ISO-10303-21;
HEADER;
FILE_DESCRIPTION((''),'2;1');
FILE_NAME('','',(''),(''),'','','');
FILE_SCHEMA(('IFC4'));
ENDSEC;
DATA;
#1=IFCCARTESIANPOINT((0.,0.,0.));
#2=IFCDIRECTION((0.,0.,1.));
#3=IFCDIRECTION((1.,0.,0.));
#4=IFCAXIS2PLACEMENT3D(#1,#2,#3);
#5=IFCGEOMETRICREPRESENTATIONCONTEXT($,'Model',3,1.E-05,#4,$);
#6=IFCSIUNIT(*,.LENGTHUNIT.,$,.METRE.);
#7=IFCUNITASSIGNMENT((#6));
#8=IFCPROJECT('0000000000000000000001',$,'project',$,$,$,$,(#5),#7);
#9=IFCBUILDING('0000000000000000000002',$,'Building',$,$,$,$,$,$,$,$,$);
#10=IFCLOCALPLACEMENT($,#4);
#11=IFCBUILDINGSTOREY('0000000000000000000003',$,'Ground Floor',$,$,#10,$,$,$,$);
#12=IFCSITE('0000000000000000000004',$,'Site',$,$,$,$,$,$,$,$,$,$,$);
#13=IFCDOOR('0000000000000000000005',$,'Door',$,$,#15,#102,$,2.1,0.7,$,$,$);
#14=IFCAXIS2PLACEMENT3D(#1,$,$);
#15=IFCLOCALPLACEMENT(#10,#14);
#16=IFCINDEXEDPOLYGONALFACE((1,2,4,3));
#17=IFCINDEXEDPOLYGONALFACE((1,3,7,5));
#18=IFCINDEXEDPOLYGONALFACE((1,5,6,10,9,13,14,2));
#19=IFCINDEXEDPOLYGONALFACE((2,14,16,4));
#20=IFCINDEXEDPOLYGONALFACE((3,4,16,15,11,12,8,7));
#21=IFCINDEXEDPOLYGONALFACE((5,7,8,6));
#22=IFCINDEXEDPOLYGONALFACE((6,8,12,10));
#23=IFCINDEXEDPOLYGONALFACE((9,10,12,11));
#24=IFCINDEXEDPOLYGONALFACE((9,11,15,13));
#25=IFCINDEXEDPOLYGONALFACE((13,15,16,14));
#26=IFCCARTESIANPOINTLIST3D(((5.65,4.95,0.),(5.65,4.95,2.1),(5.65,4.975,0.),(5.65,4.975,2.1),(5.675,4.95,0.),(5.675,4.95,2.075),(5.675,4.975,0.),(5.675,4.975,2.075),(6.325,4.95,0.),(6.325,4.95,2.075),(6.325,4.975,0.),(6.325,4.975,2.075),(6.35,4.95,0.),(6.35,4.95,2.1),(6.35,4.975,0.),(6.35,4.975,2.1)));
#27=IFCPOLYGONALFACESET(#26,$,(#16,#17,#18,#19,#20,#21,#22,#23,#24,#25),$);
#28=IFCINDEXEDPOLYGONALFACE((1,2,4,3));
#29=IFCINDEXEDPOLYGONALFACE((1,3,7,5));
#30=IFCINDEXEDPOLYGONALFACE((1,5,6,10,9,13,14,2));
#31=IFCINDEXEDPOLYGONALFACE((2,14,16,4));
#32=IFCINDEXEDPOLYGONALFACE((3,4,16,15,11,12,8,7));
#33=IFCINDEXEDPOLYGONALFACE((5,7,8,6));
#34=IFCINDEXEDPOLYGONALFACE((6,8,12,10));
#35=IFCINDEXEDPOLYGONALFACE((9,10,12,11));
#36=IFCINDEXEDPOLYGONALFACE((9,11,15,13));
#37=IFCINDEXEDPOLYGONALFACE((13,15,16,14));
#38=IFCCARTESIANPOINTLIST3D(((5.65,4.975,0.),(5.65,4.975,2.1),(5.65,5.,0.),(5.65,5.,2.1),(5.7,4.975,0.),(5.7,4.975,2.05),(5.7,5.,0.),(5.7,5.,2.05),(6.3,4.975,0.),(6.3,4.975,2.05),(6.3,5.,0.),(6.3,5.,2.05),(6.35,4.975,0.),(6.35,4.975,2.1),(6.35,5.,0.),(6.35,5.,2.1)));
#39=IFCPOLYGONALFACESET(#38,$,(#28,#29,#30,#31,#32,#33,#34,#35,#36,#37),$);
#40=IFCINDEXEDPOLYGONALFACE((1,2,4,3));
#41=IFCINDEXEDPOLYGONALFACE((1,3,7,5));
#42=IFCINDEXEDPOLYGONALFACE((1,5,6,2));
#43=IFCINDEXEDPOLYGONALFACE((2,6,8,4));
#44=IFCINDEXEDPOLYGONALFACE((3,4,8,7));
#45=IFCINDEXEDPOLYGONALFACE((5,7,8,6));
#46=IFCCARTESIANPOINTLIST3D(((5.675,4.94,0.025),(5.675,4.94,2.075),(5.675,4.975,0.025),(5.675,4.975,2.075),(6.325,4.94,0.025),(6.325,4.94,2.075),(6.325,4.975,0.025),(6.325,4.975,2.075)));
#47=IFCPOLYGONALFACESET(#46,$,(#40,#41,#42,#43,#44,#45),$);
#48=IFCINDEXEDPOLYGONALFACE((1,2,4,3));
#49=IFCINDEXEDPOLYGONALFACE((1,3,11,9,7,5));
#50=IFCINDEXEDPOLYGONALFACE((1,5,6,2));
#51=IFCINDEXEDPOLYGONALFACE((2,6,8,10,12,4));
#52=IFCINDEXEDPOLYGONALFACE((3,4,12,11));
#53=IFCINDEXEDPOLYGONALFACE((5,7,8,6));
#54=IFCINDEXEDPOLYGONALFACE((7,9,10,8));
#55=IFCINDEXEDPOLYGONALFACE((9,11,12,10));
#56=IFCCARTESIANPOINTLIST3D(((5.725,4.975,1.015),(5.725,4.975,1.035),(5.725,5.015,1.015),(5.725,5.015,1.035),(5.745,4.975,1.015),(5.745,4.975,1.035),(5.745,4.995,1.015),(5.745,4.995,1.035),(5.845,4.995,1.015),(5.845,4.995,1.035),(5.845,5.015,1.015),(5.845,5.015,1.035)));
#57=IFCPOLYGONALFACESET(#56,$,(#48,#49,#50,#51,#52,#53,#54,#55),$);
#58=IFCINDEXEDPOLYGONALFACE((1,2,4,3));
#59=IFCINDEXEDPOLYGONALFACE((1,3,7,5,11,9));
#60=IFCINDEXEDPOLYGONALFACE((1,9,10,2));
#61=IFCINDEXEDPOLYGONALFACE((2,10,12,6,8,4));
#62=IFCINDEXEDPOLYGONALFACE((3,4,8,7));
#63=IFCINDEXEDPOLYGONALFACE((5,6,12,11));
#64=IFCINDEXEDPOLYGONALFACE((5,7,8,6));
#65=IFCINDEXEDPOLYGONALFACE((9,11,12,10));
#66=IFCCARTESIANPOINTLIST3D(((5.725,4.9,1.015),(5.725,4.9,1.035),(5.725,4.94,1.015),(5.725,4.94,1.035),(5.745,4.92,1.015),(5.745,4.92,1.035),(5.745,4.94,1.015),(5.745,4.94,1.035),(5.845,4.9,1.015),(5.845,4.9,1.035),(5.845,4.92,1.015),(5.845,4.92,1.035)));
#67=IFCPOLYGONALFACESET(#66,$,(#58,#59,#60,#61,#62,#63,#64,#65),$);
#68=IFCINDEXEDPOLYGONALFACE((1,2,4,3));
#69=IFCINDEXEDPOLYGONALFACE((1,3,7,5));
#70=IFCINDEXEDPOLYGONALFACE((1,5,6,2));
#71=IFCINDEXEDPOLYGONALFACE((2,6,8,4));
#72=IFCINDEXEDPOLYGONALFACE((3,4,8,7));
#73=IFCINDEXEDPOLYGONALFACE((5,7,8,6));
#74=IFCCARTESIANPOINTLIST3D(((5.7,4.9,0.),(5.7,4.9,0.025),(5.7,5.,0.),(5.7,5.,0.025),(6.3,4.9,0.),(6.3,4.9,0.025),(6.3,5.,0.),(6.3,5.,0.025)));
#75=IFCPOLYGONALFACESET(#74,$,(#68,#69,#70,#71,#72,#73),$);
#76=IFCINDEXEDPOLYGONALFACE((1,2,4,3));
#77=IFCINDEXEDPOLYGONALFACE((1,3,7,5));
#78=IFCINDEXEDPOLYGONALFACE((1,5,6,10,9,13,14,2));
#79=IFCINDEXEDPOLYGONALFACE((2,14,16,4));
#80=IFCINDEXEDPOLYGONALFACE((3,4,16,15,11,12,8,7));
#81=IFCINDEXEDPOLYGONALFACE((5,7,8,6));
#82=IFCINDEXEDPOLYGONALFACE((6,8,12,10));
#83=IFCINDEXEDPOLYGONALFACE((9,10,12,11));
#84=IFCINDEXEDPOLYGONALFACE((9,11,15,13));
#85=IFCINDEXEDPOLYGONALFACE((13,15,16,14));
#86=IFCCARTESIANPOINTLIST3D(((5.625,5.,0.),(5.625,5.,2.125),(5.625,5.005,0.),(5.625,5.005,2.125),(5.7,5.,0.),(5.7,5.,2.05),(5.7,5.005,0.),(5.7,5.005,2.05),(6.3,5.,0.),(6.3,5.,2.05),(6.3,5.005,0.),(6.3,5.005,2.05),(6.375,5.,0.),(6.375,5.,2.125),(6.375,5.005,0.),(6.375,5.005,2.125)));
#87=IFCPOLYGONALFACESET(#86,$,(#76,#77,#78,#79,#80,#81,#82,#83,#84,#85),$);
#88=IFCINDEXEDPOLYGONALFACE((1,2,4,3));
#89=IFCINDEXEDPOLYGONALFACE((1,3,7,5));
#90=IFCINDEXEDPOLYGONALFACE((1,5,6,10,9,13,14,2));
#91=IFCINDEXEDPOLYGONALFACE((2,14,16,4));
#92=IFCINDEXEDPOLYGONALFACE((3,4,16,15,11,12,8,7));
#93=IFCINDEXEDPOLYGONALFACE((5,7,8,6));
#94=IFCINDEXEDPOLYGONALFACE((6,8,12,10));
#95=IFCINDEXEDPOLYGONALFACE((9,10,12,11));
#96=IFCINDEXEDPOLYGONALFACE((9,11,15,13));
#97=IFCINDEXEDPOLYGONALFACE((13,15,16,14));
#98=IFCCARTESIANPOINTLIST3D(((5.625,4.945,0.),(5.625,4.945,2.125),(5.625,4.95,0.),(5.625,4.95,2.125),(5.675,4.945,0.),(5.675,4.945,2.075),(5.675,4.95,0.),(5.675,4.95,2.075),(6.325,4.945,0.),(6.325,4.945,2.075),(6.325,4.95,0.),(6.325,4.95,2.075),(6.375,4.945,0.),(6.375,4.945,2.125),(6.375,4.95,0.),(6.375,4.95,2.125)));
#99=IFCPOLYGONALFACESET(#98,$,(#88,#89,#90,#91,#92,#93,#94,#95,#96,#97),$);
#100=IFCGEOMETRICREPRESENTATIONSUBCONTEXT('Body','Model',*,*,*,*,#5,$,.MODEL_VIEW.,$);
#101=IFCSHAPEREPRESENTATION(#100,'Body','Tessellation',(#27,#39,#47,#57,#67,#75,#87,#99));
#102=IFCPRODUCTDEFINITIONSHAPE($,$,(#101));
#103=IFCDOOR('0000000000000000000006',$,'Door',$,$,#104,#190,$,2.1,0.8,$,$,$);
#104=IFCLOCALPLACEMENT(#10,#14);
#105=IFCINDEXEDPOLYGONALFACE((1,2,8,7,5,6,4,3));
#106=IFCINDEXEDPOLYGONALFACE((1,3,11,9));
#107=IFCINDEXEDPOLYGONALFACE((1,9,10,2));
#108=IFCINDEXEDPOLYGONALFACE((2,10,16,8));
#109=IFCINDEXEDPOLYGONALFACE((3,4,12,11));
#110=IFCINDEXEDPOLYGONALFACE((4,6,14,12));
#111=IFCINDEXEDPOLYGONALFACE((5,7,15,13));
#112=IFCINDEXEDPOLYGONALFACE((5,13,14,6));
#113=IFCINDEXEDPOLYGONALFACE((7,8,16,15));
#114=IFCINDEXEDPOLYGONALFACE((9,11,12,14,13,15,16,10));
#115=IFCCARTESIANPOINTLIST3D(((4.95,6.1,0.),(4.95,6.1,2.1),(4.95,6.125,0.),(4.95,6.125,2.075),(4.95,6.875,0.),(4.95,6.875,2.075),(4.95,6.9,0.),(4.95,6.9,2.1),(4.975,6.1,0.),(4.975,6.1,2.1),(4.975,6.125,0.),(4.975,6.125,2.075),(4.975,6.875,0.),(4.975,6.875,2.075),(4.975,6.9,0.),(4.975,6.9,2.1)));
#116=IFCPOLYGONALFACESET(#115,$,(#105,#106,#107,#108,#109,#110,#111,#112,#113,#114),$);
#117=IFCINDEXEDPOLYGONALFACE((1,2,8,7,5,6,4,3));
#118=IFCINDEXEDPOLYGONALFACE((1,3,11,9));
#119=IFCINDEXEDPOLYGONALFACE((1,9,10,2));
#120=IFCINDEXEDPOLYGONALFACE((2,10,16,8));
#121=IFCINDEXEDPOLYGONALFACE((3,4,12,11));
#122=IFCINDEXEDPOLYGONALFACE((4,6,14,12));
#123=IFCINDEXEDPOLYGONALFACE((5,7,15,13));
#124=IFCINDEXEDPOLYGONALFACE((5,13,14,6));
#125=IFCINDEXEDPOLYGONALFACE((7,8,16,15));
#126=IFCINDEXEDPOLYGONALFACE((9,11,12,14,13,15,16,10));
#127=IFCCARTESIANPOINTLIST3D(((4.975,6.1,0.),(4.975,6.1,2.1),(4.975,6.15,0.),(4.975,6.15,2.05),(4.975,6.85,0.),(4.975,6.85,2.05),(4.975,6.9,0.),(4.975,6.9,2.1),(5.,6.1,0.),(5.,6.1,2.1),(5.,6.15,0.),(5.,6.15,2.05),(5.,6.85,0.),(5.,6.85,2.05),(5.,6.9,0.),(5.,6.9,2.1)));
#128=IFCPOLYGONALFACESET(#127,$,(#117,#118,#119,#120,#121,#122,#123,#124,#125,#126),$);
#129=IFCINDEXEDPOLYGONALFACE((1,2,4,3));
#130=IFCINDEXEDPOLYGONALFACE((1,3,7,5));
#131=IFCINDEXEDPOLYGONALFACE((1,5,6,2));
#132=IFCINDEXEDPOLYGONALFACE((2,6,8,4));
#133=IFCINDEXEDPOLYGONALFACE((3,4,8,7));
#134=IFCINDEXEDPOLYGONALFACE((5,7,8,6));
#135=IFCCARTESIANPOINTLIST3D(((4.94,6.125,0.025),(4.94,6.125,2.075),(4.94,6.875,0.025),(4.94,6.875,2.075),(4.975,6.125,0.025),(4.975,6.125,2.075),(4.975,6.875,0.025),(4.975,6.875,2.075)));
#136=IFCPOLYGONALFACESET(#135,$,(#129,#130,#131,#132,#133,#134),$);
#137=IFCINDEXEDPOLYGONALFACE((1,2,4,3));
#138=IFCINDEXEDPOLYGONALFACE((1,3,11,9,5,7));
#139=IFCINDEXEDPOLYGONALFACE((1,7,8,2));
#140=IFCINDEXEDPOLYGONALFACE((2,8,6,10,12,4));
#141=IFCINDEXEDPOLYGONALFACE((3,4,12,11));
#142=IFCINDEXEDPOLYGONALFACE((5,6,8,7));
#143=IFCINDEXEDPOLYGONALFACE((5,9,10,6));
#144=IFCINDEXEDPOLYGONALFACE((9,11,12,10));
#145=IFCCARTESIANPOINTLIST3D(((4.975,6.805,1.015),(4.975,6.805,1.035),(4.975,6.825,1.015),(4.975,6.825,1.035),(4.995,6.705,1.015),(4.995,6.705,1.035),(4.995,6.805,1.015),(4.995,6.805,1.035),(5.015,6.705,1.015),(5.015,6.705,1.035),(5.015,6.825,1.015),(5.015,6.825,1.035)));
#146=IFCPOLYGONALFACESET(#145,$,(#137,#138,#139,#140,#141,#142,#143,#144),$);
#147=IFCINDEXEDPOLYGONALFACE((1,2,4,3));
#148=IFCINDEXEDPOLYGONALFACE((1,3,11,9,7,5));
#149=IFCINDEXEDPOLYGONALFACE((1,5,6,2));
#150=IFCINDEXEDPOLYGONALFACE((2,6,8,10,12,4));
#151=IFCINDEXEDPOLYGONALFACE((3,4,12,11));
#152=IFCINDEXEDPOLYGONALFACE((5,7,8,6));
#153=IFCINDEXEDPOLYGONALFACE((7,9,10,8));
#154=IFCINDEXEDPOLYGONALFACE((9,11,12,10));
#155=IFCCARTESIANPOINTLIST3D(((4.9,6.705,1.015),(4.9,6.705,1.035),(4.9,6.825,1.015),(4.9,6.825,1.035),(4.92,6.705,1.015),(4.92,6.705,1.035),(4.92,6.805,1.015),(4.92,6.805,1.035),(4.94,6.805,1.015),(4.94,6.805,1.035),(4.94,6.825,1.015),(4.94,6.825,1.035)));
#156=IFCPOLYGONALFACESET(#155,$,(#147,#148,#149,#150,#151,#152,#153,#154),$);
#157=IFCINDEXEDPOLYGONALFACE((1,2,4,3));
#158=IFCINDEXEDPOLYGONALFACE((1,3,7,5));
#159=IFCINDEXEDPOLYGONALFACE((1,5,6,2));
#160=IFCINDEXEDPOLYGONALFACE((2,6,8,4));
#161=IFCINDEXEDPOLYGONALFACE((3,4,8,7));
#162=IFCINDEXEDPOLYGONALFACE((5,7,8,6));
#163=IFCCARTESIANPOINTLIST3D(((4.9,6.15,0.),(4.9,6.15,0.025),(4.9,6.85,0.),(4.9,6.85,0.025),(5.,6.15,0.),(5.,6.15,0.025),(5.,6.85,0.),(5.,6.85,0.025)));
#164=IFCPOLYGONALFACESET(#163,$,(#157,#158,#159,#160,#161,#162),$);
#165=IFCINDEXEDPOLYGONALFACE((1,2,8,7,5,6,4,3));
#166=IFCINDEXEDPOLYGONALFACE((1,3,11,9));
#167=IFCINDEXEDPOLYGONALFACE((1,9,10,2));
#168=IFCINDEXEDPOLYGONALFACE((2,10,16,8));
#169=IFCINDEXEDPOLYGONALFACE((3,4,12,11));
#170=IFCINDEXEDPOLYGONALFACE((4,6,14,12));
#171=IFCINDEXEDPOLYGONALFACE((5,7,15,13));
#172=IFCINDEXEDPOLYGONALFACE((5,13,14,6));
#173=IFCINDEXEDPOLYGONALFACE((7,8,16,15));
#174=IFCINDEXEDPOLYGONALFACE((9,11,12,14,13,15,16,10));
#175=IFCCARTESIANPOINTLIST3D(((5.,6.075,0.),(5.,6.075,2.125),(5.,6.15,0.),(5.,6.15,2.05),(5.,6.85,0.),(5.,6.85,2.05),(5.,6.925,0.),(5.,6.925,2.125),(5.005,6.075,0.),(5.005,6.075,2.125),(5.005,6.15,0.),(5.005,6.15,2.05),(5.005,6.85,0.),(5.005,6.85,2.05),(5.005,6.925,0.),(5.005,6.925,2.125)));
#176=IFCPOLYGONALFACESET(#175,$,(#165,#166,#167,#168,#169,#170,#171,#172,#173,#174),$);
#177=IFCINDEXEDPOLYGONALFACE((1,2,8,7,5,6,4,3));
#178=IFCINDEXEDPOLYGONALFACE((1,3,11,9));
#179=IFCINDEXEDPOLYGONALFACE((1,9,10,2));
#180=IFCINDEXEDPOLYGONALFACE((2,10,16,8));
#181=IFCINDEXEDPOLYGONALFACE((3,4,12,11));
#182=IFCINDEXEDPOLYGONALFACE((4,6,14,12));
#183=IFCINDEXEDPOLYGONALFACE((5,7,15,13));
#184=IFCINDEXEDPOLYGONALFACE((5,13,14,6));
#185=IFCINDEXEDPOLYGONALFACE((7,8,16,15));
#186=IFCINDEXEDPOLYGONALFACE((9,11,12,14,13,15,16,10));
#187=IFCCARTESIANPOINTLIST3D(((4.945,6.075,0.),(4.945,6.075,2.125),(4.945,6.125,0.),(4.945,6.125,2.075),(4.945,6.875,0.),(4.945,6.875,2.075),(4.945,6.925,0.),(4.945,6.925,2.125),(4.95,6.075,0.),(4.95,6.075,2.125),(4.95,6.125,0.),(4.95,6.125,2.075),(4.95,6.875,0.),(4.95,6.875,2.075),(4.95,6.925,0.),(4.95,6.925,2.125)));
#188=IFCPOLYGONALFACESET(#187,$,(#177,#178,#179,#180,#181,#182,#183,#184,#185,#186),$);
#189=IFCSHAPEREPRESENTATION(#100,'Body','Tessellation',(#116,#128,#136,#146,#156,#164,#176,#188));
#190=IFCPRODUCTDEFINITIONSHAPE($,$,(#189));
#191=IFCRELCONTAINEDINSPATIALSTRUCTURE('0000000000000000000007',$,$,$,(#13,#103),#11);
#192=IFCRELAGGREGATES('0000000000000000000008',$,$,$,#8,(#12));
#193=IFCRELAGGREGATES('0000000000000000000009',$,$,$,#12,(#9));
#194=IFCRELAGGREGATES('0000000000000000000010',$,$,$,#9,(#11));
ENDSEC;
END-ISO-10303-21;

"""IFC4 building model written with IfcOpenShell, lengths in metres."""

from ifc_helpers import new_model, si_unit, frame, origin_with_axes, place, context, subcontext, project, spatial, line, indexed_curve, outline, extrude, element, save


model = new_model("IFC4")

# Units and contexts
model_context = context("Model", 3, precision=1e-05, world=origin_with_axes())
body_context = subcontext(model_context, "Body", "Model", "MODEL_VIEW")
ifc_project = project(units=[si_unit("LENGTHUNIT", "METRE")], contexts=[model_context])

# Site, building, storey
site = spatial("IfcSite", under=ifc_project, Name="Site")
building = spatial("IfcBuilding", under=site, Name="Building")
storey_placement = place(None, origin_with_axes())
storey = spatial("IfcBuildingStorey", under=building, at=storey_placement, Name="Ground Floor")

# Doors
door_1_placement = place(storey_placement, frame((6.35, 5.0, 0.0), z_axis=(0.0, 0.0, 1.0), x_axis=(-1.0, 0.0, 0.0)))
element("IfcDoor", 1, at=door_1_placement, inside=storey, Name="Door", OverallHeight=2.1, OverallWidth=0.7, context=body_context, shape_type="SweptSolid", body=[
    extrude(outline(indexed_curve([(0.0, 0.0), (0.0, 2.1), (0.7, 2.1), (0.7, 0.0), (0.675, 0.0), (0.675, 2.075), (0.025, 2.075), (0.025, 0.0)], segments=[line(1, 2, 3, 4, 5, 6, 7, 8, 1)])), frame((0.0, 0.025, 0.0), z_axis=(0.0, -1.0, 0.0), x_axis=(1.0, 0.0, 0.0)), (0.0, 0.0, -1.0), 0.025),
    extrude(outline(indexed_curve([(0.0, 0.0), (0.0, 2.1), (0.7, 2.1), (0.7, 0.0), (0.65, 0.0), (0.65, 2.05), (0.05, 2.05), (0.05, 0.0)], segments=[line(1, 2, 3, 4, 5, 6, 7, 8, 1)])), frame((0.0, 0.0, 0.0), z_axis=(0.0, -1.0, 0.0), x_axis=(1.0, 0.0, 0.0)), (0.0, 0.0, -1.0), 0.025),
    extrude(outline(indexed_curve([(0.0, 0.0), (0.65, 0.0), (0.65, 0.035), (0.0, 0.035)], segments=[line(1, 2, 3, 4, 1)])), frame((0.025, 0.025, 0.025), z_axis=(0.0, 0.0, 1.0), x_axis=(1.0, 0.0, 0.0)), (0.0, 0.0, 1.0), 2.05),
    extrude(outline(indexed_curve([(0.0, 0.0), (0.0, -0.04), (-0.12, -0.04), (-0.12, -0.02), (-0.02, -0.02), (-0.02, 0.0)], segments=[line(1, 2, 3, 4, 5, 6, 1)])), frame((0.625, 0.025, 1.015), z_axis=(0.0, 0.0, 1.0), x_axis=(1.0, 0.0, 0.0)), (0.0, 0.0, 1.0), 0.02),
    extrude(outline(indexed_curve([(0.0, 0.0), (0.0, 0.04), (-0.12, 0.04), (-0.12, 0.02), (-0.02, 0.02), (-0.02, 0.0)], segments=[line(1, 2, 3, 4, 5, 6, 1)])), frame((0.625, 0.06, 1.015), z_axis=(0.0, 0.0, 1.0), x_axis=(1.0, 0.0, 0.0)), (0.0, 0.0, 1.0), 0.02),
    extrude(outline(indexed_curve([(0.0, 0.0), (0.6, 0.0), (0.6, 0.1), (0.0, 0.1)], segments=[line(1, 2, 3, 4, 1)])), frame((0.05, 0.0, 0.0), z_axis=(0.0, 0.0, 1.0), x_axis=(1.0, 0.0, 0.0)), (0.0, 0.0, 1.0), 0.025),
    extrude(outline(indexed_curve([(0.0, 0.0), (0.0, 2.125), (0.75, 2.125), (0.75, 0.0), (0.675, 0.0), (0.675, 2.05), (0.075, 2.05), (0.075, 0.0)], segments=[line(1, 2, 3, 4, 5, 6, 7, 8, 1)])), frame((-0.025, -0.005, 0.0), z_axis=(0.0, -1.0, 0.0), x_axis=(1.0, 0.0, 0.0)), (0.0, 0.0, -1.0), 0.005),
    extrude(outline(indexed_curve([(0.0, 0.0), (0.0, 2.125), (0.75, 2.125), (0.75, 0.0), (0.7, 0.0), (0.7, 2.075), (0.05, 2.075), (0.05, 0.0)], segments=[line(1, 2, 3, 4, 5, 6, 7, 8, 1)])), frame((-0.025, 0.05, 0.0), z_axis=(0.0, -1.0, 0.0), x_axis=(1.0, 0.0, 0.0)), (0.0, 0.0, -1.0), 0.005),
])
door_2_placement = place(storey_placement, frame((5.0, 6.1, 0.0), z_axis=(0.0, 0.0, 1.0), x_axis=(0.0, 1.0, 0.0)))
element("IfcDoor", 2, at=door_2_placement, inside=storey, Name="Door", OverallHeight=2.1, OverallWidth=0.8, context=body_context, shape_type="SweptSolid", body=[
    extrude(outline(indexed_curve([(0.0, 0.0), (0.0, 2.1), (0.8, 2.1), (0.8, 0.0), (0.775, 0.0), (0.775, 2.075), (0.025, 2.075), (0.025, 0.0)], segments=[line(1, 2, 3, 4, 5, 6, 7, 8, 1)])), frame((0.0, 0.025, 0.0), z_axis=(0.0, -1.0, 0.0), x_axis=(1.0, 0.0, 0.0)), (0.0, 0.0, -1.0), 0.025),
    extrude(outline(indexed_curve([(0.0, 0.0), (0.0, 2.1), (0.8, 2.1), (0.8, 0.0), (0.75, 0.0), (0.75, 2.05), (0.05, 2.05), (0.05, 0.0)], segments=[line(1, 2, 3, 4, 5, 6, 7, 8, 1)])), frame((0.0, 0.0, 0.0), z_axis=(0.0, -1.0, 0.0), x_axis=(1.0, 0.0, 0.0)), (0.0, 0.0, -1.0), 0.025),
    extrude(outline(indexed_curve([(0.0, 0.0), (0.75, 0.0), (0.75, 0.035), (0.0, 0.035)], segments=[line(1, 2, 3, 4, 1)])), frame((0.025, 0.025, 0.025), z_axis=(0.0, 0.0, 1.0), x_axis=(1.0, 0.0, 0.0)), (0.0, 0.0, 1.0), 2.05),
    extrude(outline(indexed_curve([(0.0, 0.0), (0.0, -0.04), (-0.12, -0.04), (-0.12, -0.02), (-0.02, -0.02), (-0.02, 0.0)], segments=[line(1, 2, 3, 4, 5, 6, 1)])), frame((0.725, 0.025, 1.015), z_axis=(0.0, 0.0, 1.0), x_axis=(1.0, 0.0, 0.0)), (0.0, 0.0, 1.0), 0.02),
    extrude(outline(indexed_curve([(0.0, 0.0), (0.0, 0.04), (-0.12, 0.04), (-0.12, 0.02), (-0.02, 0.02), (-0.02, 0.0)], segments=[line(1, 2, 3, 4, 5, 6, 1)])), frame((0.725, 0.06, 1.015), z_axis=(0.0, 0.0, 1.0), x_axis=(1.0, 0.0, 0.0)), (0.0, 0.0, 1.0), 0.02),
    extrude(outline(indexed_curve([(0.0, 0.0), (0.7, 0.0), (0.7, 0.1), (0.0, 0.1)], segments=[line(1, 2, 3, 4, 1)])), frame((0.05, 0.0, 0.0), z_axis=(0.0, 0.0, 1.0), x_axis=(1.0, 0.0, 0.0)), (0.0, 0.0, 1.0), 0.025),
    extrude(outline(indexed_curve([(0.0, 0.0), (0.0, 2.125), (0.85, 2.125), (0.85, 0.0), (0.775, 0.0), (0.775, 2.05), (0.075, 2.05), (0.075, 0.0)], segments=[line(1, 2, 3, 4, 5, 6, 7, 8, 1)])), frame((-0.025, -0.005, 0.0), z_axis=(0.0, -1.0, 0.0), x_axis=(1.0, 0.0, 0.0)), (0.0, 0.0, -1.0), 0.005),
    extrude(outline(indexed_curve([(0.0, 0.0), (0.0, 2.125), (0.85, 2.125), (0.85, 0.0), (0.8, 0.0), (0.8, 2.075), (0.05, 2.075), (0.05, 0.0)], segments=[line(1, 2, 3, 4, 5, 6, 7, 8, 1)])), frame((-0.025, 0.05, 0.0), z_axis=(0.0, -1.0, 0.0), x_axis=(1.0, 0.0, 0.0)), (0.0, 0.0, -1.0), 0.005),
])

save(model, "model.ifc")
